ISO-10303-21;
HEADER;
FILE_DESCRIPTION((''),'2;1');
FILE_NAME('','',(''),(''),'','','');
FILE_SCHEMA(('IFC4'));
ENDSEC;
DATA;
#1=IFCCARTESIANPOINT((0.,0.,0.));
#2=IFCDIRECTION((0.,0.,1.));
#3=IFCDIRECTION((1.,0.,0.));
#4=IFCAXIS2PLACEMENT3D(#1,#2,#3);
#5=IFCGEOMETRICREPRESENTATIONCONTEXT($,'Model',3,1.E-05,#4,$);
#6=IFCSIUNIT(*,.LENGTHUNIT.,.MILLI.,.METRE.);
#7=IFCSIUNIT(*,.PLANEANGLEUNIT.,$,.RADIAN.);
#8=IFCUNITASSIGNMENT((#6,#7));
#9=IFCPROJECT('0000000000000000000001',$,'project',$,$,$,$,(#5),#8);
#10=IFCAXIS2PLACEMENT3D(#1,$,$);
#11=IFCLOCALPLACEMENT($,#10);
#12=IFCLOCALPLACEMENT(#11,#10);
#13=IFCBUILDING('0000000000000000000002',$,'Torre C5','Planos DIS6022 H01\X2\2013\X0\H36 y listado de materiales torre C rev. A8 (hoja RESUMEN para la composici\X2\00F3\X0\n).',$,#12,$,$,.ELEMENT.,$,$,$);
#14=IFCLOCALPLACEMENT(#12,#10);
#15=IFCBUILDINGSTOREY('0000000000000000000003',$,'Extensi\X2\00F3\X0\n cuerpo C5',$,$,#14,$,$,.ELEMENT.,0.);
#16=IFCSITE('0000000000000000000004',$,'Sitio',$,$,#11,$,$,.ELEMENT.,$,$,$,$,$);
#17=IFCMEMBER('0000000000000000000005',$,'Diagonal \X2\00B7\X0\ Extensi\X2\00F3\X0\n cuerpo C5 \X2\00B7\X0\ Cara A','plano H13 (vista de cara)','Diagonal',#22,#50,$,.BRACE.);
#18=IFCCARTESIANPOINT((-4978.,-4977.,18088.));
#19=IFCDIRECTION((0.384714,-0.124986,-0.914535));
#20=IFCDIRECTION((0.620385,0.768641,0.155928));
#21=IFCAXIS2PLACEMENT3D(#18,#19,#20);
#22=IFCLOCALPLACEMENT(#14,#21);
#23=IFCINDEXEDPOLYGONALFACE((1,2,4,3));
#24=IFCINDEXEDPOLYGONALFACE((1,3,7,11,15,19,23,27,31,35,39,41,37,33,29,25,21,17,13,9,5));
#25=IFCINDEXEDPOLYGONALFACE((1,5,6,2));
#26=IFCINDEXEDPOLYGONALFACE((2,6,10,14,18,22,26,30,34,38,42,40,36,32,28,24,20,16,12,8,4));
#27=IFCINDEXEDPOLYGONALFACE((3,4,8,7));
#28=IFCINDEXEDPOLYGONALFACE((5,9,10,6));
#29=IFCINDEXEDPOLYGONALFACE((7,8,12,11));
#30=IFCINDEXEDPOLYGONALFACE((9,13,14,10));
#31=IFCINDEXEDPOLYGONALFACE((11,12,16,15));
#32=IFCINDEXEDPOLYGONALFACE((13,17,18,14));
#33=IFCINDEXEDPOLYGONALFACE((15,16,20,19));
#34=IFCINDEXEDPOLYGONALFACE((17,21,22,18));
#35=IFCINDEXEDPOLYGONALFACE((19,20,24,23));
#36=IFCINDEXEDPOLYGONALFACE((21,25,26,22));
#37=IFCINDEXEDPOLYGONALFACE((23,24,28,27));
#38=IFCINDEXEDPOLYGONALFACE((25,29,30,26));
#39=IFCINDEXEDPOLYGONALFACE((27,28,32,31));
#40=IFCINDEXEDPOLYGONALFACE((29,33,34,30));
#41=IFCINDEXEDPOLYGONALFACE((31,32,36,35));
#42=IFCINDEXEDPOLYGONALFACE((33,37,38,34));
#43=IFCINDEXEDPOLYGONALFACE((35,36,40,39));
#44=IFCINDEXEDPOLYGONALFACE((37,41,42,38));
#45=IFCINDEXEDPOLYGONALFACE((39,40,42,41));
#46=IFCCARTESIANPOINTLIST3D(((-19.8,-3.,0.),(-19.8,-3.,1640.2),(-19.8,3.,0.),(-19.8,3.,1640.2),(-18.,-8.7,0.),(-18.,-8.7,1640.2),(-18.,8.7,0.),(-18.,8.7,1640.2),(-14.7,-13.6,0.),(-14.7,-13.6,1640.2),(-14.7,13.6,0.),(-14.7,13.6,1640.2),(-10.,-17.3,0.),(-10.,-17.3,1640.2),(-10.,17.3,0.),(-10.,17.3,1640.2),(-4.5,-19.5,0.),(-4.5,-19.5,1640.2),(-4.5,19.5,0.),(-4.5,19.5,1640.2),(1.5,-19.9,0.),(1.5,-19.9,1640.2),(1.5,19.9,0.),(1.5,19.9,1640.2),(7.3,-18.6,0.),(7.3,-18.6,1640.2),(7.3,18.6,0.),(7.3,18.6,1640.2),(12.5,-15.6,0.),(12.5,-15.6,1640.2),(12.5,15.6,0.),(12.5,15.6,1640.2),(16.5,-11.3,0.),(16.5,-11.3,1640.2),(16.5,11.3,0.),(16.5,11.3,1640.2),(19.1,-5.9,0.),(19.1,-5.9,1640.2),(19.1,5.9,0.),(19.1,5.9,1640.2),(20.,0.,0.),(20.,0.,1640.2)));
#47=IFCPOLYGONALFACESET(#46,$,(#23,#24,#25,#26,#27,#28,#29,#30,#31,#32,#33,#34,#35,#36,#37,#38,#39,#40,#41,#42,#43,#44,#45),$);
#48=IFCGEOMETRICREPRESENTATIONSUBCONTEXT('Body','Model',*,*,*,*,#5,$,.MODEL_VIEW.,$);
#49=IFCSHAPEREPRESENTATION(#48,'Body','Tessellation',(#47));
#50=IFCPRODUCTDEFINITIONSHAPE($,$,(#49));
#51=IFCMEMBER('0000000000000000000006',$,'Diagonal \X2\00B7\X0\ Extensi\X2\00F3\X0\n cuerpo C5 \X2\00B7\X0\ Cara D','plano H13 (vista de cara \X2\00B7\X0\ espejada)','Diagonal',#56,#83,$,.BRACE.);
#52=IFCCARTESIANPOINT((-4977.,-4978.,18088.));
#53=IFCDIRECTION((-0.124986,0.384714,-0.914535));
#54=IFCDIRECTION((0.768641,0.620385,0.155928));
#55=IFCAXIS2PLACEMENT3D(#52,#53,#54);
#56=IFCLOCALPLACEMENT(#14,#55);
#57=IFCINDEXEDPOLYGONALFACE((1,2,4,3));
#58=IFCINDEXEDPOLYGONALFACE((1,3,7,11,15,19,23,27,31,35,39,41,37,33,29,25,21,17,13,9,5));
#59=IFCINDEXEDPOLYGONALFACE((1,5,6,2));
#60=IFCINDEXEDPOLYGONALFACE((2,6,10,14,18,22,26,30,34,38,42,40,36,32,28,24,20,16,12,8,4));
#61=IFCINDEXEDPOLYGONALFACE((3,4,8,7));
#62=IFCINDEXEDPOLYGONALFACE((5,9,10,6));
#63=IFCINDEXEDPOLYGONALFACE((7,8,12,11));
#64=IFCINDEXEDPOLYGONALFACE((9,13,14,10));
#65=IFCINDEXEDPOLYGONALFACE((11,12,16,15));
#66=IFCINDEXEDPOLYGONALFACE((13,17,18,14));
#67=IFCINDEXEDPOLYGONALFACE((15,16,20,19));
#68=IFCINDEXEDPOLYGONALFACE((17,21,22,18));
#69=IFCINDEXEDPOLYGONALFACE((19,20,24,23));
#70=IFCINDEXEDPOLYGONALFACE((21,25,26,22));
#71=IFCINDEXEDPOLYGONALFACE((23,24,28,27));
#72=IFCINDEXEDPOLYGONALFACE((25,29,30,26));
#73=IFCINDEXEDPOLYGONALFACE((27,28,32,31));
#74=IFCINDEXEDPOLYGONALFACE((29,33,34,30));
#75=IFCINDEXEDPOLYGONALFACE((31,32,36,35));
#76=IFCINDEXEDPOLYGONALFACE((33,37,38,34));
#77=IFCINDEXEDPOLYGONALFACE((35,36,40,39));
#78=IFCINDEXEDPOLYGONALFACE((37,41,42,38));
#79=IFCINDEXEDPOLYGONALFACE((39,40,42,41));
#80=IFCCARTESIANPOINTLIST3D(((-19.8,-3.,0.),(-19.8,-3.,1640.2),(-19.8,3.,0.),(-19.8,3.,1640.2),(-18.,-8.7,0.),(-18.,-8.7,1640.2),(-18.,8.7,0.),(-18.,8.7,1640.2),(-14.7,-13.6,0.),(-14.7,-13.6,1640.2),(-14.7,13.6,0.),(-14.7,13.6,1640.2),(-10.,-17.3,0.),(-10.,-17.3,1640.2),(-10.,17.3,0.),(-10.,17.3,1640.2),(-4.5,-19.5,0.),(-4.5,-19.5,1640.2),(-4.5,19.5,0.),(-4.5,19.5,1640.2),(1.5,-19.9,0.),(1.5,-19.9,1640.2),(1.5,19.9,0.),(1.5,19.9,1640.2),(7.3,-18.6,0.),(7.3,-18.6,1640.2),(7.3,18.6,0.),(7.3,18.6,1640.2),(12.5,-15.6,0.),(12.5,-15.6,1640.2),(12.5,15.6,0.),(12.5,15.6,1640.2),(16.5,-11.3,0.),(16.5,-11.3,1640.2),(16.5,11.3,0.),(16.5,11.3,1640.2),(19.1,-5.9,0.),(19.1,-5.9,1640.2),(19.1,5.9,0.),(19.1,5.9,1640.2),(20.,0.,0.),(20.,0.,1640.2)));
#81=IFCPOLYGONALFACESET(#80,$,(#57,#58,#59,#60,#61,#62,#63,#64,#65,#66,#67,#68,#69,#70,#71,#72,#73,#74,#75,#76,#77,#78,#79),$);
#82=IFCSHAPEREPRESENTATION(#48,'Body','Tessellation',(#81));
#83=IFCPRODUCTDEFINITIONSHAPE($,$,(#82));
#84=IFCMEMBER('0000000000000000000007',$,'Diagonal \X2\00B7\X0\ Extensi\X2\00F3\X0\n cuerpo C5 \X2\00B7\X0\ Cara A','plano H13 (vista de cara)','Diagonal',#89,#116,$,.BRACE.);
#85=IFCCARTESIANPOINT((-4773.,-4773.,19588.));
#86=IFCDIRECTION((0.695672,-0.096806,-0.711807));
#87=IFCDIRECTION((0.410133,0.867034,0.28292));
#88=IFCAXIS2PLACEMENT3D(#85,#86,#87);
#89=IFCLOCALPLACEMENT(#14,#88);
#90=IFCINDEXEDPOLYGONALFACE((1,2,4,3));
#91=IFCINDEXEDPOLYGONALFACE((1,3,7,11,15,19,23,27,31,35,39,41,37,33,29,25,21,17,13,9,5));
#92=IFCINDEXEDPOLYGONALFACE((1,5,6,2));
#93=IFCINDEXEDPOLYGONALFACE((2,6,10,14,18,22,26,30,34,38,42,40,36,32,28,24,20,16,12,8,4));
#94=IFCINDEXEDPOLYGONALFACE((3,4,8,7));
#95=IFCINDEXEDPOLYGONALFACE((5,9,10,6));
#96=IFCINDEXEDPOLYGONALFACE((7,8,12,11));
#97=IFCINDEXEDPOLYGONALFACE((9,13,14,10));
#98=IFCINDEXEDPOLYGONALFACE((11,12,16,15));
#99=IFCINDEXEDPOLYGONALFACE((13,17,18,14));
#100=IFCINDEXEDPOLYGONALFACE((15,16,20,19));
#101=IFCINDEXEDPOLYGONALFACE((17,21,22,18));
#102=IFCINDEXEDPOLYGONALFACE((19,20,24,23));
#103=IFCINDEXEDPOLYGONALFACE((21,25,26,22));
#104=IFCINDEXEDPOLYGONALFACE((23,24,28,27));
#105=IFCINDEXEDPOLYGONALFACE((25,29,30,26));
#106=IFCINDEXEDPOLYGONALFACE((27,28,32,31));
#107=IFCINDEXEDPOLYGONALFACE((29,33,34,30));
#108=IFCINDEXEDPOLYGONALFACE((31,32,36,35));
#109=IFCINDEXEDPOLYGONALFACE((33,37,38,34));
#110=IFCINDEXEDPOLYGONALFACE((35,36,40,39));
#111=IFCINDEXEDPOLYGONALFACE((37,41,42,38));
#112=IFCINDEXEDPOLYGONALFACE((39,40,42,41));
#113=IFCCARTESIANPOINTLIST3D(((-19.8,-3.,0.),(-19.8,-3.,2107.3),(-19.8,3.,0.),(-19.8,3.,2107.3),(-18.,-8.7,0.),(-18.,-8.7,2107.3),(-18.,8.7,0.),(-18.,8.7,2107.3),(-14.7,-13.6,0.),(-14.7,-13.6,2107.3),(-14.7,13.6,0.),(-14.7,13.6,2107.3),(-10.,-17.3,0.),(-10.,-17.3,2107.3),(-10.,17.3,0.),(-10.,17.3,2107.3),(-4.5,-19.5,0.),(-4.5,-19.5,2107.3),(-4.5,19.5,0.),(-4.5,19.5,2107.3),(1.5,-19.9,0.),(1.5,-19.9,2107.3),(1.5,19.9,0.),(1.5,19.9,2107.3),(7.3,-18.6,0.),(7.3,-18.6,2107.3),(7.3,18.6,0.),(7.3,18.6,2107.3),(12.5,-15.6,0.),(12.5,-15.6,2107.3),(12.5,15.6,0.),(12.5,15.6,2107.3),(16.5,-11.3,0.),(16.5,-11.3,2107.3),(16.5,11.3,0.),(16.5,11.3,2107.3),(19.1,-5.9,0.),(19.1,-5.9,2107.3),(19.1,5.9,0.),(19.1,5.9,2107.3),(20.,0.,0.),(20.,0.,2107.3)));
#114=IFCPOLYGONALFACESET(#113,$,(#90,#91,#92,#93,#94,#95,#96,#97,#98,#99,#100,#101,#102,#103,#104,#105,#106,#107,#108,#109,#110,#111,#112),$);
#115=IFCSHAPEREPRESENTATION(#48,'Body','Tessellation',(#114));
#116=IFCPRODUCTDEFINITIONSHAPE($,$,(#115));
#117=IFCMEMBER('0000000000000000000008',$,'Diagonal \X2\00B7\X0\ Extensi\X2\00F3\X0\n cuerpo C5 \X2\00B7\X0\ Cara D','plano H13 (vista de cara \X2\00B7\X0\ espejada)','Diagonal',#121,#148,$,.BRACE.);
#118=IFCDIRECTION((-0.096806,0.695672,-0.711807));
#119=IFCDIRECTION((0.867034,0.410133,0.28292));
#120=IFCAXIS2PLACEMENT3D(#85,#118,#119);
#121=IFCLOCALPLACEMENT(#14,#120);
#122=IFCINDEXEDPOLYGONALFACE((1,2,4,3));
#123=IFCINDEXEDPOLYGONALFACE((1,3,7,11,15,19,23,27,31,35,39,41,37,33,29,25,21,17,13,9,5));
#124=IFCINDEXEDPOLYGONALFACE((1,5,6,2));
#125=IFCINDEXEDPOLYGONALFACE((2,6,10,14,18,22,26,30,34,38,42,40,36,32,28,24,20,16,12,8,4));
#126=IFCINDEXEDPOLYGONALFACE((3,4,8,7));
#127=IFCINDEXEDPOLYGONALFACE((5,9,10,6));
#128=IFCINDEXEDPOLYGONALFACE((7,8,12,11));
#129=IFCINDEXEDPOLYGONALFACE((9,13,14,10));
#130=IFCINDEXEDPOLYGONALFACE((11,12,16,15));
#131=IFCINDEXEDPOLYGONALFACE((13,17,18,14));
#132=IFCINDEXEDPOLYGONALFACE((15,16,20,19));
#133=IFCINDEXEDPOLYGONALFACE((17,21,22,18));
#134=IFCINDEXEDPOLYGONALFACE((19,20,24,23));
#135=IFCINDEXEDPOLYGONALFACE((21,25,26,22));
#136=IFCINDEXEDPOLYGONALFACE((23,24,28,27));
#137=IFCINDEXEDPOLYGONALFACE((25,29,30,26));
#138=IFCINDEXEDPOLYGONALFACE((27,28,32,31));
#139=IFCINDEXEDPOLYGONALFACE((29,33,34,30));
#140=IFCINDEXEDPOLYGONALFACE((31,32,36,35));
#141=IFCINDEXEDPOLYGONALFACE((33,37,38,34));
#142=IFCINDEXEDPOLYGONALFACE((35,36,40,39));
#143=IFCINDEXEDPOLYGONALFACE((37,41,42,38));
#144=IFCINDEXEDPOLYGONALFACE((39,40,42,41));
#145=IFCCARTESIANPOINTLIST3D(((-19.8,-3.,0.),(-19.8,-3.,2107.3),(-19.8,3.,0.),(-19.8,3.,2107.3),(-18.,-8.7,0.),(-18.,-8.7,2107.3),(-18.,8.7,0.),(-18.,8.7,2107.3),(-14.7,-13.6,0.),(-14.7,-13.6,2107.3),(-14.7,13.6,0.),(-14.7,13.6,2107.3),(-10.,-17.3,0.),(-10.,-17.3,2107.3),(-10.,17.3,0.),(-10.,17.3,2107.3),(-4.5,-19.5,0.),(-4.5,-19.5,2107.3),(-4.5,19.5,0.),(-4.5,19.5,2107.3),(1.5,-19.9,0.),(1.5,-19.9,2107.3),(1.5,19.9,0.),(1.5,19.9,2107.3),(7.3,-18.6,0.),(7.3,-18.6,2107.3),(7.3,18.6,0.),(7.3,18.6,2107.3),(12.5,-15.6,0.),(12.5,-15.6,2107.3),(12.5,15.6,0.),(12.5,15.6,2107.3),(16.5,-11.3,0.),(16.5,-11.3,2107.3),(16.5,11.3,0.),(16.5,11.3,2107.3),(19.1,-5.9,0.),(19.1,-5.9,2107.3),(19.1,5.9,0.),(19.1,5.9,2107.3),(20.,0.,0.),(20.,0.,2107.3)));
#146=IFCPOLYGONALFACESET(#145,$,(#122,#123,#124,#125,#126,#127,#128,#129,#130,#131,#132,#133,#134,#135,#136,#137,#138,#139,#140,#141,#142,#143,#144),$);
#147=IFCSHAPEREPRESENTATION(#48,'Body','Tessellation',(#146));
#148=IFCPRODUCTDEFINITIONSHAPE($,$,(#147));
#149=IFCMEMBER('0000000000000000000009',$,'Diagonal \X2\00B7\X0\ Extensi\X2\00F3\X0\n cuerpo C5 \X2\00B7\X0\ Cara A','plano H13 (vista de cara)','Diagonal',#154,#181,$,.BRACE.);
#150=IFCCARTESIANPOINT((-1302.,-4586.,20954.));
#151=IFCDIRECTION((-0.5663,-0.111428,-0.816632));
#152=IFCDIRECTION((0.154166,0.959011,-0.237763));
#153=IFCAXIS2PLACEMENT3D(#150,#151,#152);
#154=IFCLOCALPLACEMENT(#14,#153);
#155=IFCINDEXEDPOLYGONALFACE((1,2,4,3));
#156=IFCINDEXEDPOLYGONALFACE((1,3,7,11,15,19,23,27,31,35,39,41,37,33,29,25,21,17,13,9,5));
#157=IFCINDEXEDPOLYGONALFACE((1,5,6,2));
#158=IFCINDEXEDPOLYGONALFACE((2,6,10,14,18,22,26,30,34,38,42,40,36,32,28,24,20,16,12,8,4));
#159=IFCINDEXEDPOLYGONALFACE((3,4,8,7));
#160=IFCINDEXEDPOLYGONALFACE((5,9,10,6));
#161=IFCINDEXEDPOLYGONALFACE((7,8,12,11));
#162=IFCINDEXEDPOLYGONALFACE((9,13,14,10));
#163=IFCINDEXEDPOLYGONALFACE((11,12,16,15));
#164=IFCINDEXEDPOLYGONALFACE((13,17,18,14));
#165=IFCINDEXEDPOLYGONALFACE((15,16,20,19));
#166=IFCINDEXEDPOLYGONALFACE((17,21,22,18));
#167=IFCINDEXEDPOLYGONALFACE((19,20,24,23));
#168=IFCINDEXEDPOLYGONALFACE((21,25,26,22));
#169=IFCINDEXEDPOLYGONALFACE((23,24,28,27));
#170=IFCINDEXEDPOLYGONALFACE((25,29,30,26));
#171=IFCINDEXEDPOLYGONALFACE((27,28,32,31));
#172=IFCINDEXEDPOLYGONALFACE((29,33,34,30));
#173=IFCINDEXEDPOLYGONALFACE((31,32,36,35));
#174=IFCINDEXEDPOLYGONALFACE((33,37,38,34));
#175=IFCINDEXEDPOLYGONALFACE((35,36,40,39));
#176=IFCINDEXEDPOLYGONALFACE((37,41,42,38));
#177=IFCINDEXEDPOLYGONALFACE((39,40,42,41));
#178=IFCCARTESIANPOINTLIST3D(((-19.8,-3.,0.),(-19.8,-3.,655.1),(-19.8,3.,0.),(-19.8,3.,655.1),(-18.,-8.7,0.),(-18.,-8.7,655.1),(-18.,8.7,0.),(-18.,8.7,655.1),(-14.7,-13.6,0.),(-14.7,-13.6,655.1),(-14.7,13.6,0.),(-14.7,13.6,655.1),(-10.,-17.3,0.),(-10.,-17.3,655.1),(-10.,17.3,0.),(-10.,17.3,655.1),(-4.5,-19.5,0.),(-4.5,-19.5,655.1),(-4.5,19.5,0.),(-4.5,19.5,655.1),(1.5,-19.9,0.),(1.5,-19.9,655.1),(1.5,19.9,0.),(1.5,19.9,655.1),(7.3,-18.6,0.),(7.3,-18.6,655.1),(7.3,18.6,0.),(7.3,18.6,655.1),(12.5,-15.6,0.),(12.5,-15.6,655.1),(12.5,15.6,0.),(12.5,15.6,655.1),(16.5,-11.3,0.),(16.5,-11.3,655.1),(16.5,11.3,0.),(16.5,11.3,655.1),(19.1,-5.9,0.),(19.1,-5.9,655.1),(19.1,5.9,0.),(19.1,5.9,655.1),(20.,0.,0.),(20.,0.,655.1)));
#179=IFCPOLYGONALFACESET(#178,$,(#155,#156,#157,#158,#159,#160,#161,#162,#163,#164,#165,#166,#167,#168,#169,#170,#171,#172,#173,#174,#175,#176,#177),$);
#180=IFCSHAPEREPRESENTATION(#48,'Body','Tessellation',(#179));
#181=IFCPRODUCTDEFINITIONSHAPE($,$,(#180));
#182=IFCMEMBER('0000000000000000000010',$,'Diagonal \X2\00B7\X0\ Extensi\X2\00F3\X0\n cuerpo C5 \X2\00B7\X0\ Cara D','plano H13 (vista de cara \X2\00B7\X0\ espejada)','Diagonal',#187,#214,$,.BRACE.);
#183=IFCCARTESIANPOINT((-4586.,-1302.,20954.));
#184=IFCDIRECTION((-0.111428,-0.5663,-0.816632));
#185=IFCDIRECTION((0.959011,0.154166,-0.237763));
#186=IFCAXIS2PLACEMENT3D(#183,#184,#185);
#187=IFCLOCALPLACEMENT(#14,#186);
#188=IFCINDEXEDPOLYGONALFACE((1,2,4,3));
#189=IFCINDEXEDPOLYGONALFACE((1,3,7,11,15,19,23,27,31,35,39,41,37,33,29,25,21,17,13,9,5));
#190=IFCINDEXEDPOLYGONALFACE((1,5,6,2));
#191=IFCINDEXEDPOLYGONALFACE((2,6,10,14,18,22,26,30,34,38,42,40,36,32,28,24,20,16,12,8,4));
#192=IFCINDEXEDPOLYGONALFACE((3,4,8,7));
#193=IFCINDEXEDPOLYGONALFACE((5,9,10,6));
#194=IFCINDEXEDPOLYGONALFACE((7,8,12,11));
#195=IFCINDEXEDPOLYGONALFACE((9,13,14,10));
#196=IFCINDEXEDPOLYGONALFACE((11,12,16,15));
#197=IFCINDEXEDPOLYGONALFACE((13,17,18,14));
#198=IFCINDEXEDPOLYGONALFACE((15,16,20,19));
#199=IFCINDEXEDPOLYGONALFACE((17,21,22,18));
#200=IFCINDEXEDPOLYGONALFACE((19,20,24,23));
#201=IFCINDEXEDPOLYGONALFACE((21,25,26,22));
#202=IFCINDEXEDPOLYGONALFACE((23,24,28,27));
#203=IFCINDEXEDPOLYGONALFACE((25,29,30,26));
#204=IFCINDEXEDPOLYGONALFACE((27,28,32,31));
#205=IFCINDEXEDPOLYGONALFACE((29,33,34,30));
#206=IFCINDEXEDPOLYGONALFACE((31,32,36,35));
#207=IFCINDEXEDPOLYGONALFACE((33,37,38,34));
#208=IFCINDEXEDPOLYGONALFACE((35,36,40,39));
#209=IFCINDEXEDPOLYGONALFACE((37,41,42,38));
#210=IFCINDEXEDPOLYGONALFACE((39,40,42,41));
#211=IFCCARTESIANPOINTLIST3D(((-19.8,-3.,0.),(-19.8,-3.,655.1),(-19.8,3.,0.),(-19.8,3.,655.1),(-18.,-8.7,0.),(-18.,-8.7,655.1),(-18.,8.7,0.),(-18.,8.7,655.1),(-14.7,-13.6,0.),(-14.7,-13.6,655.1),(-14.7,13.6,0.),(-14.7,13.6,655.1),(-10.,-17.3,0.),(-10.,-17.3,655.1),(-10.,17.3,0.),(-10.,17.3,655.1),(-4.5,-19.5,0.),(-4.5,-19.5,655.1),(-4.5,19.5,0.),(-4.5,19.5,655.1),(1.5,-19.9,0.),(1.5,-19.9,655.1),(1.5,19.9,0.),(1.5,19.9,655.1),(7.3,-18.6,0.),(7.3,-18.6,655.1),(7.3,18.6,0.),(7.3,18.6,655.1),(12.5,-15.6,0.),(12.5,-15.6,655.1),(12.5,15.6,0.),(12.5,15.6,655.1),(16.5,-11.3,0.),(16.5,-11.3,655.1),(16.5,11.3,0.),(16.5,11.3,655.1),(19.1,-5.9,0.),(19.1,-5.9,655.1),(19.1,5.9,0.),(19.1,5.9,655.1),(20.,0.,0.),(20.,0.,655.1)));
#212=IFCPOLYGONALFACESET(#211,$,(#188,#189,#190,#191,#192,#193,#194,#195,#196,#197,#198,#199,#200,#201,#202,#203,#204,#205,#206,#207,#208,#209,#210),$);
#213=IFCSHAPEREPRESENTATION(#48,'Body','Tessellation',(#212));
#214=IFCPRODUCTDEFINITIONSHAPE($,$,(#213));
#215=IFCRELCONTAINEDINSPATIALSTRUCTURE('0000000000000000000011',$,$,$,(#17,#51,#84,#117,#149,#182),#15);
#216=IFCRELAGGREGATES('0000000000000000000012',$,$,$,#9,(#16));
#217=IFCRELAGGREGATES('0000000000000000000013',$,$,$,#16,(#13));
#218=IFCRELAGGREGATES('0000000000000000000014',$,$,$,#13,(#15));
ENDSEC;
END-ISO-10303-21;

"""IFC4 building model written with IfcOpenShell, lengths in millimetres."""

from ifc_helpers import new_model, si_unit, frame, origin, origin_with_axes, place, context, subcontext, project, spatial, circle, extrude, element, save


model = new_model("IFC4")

# Units and contexts
model_context = context("Model", 3, precision=1e-05, world=origin_with_axes())
body_context = subcontext(model_context, "Body", "Model", "MODEL_VIEW")
ifc_project = project(units=[si_unit("LENGTHUNIT", "METRE", prefix="MILLI"), si_unit("PLANEANGLEUNIT", "RADIAN")], contexts=[model_context])

# Site, building, storey
site_placement = place(None, origin())
site = spatial("IfcSite", under=ifc_project, at=site_placement, Name="Sitio", CompositionType="ELEMENT")
building_placement = place(site_placement, origin())
building = spatial("IfcBuilding", under=site, at=building_placement, Name="Torre C5", Description="Planos DIS6022 H01–H36 y listado de materiales torre C rev. A8 (hoja RESUMEN para la composición).", CompositionType="ELEMENT")
storey_placement = place(building_placement, origin())
storey = spatial("IfcBuildingStorey", under=building, at=storey_placement, Name="Extensión cuerpo C5", CompositionType="ELEMENT", Elevation=0.0)

# Members
for number, where, z_axis, x_axis, name, description in (
    (1, (-4978.0, -4977.0, 18088.0), (0.384714, -0.124986, -0.914535), (0.620385, 0.768641, 0.155928), "Diagonal · Extensión cuerpo C5 · Cara A", "plano H13 (vista de cara)"),
    (2, (-4977.0, -4978.0, 18088.0), (-0.124986, 0.384714, -0.914535), (0.768641, 0.620385, 0.155928), "Diagonal · Extensión cuerpo C5 · Cara D", "plano H13 (vista de cara · espejada)"),
):
    element("IfcMember", number, at=place(storey_placement, frame(where, z_axis=z_axis, x_axis=x_axis)), inside=storey, Name=name, Description=description, ObjectType="Diagonal", PredefinedType="BRACE", context=body_context, shape_type="SweptSolid", body=[
        extrude(circle(Radius=20.0), None, (0.0, 0.0, 1.0), 1640.2),
    ])
for number, where, z_axis, x_axis, name, description in (
    (3, (-4773.0, -4773.0, 19588.0), (0.695672, -0.096806, -0.711807), (0.410133, 0.867034, 0.28292), "Diagonal · Extensión cuerpo C5 · Cara A", "plano H13 (vista de cara)"),
    (4, (-4773.0, -4773.0, 19588.0), (-0.096806, 0.695672, -0.711807), (0.867034, 0.410133, 0.28292), "Diagonal · Extensión cuerpo C5 · Cara D", "plano H13 (vista de cara · espejada)"),
):
    element("IfcMember", number, at=place(storey_placement, frame(where, z_axis=z_axis, x_axis=x_axis)), inside=storey, Name=name, Description=description, ObjectType="Diagonal", PredefinedType="BRACE", context=body_context, shape_type="SweptSolid", body=[
        extrude(circle(Radius=20.0), None, (0.0, 0.0, 1.0), 2107.3),
    ])
for number, where, z_axis, x_axis, name, description in (
    (5, (-1302.0, -4586.0, 20954.0), (-0.5663, -0.111428, -0.816632), (0.154166, 0.959011, -0.237763), "Diagonal · Extensión cuerpo C5 · Cara A", "plano H13 (vista de cara)"),
    (6, (-4586.0, -1302.0, 20954.0), (-0.111428, -0.5663, -0.816632), (0.959011, 0.154166, -0.237763), "Diagonal · Extensión cuerpo C5 · Cara D", "plano H13 (vista de cara · espejada)"),
):
    element("IfcMember", number, at=place(storey_placement, frame(where, z_axis=z_axis, x_axis=x_axis)), inside=storey, Name=name, Description=description, ObjectType="Diagonal", PredefinedType="BRACE", context=body_context, shape_type="SweptSolid", body=[
        extrude(circle(Radius=20.0), None, (0.0, 0.0, 1.0), 655.1),
    ])

save(model, "model.ifc")
